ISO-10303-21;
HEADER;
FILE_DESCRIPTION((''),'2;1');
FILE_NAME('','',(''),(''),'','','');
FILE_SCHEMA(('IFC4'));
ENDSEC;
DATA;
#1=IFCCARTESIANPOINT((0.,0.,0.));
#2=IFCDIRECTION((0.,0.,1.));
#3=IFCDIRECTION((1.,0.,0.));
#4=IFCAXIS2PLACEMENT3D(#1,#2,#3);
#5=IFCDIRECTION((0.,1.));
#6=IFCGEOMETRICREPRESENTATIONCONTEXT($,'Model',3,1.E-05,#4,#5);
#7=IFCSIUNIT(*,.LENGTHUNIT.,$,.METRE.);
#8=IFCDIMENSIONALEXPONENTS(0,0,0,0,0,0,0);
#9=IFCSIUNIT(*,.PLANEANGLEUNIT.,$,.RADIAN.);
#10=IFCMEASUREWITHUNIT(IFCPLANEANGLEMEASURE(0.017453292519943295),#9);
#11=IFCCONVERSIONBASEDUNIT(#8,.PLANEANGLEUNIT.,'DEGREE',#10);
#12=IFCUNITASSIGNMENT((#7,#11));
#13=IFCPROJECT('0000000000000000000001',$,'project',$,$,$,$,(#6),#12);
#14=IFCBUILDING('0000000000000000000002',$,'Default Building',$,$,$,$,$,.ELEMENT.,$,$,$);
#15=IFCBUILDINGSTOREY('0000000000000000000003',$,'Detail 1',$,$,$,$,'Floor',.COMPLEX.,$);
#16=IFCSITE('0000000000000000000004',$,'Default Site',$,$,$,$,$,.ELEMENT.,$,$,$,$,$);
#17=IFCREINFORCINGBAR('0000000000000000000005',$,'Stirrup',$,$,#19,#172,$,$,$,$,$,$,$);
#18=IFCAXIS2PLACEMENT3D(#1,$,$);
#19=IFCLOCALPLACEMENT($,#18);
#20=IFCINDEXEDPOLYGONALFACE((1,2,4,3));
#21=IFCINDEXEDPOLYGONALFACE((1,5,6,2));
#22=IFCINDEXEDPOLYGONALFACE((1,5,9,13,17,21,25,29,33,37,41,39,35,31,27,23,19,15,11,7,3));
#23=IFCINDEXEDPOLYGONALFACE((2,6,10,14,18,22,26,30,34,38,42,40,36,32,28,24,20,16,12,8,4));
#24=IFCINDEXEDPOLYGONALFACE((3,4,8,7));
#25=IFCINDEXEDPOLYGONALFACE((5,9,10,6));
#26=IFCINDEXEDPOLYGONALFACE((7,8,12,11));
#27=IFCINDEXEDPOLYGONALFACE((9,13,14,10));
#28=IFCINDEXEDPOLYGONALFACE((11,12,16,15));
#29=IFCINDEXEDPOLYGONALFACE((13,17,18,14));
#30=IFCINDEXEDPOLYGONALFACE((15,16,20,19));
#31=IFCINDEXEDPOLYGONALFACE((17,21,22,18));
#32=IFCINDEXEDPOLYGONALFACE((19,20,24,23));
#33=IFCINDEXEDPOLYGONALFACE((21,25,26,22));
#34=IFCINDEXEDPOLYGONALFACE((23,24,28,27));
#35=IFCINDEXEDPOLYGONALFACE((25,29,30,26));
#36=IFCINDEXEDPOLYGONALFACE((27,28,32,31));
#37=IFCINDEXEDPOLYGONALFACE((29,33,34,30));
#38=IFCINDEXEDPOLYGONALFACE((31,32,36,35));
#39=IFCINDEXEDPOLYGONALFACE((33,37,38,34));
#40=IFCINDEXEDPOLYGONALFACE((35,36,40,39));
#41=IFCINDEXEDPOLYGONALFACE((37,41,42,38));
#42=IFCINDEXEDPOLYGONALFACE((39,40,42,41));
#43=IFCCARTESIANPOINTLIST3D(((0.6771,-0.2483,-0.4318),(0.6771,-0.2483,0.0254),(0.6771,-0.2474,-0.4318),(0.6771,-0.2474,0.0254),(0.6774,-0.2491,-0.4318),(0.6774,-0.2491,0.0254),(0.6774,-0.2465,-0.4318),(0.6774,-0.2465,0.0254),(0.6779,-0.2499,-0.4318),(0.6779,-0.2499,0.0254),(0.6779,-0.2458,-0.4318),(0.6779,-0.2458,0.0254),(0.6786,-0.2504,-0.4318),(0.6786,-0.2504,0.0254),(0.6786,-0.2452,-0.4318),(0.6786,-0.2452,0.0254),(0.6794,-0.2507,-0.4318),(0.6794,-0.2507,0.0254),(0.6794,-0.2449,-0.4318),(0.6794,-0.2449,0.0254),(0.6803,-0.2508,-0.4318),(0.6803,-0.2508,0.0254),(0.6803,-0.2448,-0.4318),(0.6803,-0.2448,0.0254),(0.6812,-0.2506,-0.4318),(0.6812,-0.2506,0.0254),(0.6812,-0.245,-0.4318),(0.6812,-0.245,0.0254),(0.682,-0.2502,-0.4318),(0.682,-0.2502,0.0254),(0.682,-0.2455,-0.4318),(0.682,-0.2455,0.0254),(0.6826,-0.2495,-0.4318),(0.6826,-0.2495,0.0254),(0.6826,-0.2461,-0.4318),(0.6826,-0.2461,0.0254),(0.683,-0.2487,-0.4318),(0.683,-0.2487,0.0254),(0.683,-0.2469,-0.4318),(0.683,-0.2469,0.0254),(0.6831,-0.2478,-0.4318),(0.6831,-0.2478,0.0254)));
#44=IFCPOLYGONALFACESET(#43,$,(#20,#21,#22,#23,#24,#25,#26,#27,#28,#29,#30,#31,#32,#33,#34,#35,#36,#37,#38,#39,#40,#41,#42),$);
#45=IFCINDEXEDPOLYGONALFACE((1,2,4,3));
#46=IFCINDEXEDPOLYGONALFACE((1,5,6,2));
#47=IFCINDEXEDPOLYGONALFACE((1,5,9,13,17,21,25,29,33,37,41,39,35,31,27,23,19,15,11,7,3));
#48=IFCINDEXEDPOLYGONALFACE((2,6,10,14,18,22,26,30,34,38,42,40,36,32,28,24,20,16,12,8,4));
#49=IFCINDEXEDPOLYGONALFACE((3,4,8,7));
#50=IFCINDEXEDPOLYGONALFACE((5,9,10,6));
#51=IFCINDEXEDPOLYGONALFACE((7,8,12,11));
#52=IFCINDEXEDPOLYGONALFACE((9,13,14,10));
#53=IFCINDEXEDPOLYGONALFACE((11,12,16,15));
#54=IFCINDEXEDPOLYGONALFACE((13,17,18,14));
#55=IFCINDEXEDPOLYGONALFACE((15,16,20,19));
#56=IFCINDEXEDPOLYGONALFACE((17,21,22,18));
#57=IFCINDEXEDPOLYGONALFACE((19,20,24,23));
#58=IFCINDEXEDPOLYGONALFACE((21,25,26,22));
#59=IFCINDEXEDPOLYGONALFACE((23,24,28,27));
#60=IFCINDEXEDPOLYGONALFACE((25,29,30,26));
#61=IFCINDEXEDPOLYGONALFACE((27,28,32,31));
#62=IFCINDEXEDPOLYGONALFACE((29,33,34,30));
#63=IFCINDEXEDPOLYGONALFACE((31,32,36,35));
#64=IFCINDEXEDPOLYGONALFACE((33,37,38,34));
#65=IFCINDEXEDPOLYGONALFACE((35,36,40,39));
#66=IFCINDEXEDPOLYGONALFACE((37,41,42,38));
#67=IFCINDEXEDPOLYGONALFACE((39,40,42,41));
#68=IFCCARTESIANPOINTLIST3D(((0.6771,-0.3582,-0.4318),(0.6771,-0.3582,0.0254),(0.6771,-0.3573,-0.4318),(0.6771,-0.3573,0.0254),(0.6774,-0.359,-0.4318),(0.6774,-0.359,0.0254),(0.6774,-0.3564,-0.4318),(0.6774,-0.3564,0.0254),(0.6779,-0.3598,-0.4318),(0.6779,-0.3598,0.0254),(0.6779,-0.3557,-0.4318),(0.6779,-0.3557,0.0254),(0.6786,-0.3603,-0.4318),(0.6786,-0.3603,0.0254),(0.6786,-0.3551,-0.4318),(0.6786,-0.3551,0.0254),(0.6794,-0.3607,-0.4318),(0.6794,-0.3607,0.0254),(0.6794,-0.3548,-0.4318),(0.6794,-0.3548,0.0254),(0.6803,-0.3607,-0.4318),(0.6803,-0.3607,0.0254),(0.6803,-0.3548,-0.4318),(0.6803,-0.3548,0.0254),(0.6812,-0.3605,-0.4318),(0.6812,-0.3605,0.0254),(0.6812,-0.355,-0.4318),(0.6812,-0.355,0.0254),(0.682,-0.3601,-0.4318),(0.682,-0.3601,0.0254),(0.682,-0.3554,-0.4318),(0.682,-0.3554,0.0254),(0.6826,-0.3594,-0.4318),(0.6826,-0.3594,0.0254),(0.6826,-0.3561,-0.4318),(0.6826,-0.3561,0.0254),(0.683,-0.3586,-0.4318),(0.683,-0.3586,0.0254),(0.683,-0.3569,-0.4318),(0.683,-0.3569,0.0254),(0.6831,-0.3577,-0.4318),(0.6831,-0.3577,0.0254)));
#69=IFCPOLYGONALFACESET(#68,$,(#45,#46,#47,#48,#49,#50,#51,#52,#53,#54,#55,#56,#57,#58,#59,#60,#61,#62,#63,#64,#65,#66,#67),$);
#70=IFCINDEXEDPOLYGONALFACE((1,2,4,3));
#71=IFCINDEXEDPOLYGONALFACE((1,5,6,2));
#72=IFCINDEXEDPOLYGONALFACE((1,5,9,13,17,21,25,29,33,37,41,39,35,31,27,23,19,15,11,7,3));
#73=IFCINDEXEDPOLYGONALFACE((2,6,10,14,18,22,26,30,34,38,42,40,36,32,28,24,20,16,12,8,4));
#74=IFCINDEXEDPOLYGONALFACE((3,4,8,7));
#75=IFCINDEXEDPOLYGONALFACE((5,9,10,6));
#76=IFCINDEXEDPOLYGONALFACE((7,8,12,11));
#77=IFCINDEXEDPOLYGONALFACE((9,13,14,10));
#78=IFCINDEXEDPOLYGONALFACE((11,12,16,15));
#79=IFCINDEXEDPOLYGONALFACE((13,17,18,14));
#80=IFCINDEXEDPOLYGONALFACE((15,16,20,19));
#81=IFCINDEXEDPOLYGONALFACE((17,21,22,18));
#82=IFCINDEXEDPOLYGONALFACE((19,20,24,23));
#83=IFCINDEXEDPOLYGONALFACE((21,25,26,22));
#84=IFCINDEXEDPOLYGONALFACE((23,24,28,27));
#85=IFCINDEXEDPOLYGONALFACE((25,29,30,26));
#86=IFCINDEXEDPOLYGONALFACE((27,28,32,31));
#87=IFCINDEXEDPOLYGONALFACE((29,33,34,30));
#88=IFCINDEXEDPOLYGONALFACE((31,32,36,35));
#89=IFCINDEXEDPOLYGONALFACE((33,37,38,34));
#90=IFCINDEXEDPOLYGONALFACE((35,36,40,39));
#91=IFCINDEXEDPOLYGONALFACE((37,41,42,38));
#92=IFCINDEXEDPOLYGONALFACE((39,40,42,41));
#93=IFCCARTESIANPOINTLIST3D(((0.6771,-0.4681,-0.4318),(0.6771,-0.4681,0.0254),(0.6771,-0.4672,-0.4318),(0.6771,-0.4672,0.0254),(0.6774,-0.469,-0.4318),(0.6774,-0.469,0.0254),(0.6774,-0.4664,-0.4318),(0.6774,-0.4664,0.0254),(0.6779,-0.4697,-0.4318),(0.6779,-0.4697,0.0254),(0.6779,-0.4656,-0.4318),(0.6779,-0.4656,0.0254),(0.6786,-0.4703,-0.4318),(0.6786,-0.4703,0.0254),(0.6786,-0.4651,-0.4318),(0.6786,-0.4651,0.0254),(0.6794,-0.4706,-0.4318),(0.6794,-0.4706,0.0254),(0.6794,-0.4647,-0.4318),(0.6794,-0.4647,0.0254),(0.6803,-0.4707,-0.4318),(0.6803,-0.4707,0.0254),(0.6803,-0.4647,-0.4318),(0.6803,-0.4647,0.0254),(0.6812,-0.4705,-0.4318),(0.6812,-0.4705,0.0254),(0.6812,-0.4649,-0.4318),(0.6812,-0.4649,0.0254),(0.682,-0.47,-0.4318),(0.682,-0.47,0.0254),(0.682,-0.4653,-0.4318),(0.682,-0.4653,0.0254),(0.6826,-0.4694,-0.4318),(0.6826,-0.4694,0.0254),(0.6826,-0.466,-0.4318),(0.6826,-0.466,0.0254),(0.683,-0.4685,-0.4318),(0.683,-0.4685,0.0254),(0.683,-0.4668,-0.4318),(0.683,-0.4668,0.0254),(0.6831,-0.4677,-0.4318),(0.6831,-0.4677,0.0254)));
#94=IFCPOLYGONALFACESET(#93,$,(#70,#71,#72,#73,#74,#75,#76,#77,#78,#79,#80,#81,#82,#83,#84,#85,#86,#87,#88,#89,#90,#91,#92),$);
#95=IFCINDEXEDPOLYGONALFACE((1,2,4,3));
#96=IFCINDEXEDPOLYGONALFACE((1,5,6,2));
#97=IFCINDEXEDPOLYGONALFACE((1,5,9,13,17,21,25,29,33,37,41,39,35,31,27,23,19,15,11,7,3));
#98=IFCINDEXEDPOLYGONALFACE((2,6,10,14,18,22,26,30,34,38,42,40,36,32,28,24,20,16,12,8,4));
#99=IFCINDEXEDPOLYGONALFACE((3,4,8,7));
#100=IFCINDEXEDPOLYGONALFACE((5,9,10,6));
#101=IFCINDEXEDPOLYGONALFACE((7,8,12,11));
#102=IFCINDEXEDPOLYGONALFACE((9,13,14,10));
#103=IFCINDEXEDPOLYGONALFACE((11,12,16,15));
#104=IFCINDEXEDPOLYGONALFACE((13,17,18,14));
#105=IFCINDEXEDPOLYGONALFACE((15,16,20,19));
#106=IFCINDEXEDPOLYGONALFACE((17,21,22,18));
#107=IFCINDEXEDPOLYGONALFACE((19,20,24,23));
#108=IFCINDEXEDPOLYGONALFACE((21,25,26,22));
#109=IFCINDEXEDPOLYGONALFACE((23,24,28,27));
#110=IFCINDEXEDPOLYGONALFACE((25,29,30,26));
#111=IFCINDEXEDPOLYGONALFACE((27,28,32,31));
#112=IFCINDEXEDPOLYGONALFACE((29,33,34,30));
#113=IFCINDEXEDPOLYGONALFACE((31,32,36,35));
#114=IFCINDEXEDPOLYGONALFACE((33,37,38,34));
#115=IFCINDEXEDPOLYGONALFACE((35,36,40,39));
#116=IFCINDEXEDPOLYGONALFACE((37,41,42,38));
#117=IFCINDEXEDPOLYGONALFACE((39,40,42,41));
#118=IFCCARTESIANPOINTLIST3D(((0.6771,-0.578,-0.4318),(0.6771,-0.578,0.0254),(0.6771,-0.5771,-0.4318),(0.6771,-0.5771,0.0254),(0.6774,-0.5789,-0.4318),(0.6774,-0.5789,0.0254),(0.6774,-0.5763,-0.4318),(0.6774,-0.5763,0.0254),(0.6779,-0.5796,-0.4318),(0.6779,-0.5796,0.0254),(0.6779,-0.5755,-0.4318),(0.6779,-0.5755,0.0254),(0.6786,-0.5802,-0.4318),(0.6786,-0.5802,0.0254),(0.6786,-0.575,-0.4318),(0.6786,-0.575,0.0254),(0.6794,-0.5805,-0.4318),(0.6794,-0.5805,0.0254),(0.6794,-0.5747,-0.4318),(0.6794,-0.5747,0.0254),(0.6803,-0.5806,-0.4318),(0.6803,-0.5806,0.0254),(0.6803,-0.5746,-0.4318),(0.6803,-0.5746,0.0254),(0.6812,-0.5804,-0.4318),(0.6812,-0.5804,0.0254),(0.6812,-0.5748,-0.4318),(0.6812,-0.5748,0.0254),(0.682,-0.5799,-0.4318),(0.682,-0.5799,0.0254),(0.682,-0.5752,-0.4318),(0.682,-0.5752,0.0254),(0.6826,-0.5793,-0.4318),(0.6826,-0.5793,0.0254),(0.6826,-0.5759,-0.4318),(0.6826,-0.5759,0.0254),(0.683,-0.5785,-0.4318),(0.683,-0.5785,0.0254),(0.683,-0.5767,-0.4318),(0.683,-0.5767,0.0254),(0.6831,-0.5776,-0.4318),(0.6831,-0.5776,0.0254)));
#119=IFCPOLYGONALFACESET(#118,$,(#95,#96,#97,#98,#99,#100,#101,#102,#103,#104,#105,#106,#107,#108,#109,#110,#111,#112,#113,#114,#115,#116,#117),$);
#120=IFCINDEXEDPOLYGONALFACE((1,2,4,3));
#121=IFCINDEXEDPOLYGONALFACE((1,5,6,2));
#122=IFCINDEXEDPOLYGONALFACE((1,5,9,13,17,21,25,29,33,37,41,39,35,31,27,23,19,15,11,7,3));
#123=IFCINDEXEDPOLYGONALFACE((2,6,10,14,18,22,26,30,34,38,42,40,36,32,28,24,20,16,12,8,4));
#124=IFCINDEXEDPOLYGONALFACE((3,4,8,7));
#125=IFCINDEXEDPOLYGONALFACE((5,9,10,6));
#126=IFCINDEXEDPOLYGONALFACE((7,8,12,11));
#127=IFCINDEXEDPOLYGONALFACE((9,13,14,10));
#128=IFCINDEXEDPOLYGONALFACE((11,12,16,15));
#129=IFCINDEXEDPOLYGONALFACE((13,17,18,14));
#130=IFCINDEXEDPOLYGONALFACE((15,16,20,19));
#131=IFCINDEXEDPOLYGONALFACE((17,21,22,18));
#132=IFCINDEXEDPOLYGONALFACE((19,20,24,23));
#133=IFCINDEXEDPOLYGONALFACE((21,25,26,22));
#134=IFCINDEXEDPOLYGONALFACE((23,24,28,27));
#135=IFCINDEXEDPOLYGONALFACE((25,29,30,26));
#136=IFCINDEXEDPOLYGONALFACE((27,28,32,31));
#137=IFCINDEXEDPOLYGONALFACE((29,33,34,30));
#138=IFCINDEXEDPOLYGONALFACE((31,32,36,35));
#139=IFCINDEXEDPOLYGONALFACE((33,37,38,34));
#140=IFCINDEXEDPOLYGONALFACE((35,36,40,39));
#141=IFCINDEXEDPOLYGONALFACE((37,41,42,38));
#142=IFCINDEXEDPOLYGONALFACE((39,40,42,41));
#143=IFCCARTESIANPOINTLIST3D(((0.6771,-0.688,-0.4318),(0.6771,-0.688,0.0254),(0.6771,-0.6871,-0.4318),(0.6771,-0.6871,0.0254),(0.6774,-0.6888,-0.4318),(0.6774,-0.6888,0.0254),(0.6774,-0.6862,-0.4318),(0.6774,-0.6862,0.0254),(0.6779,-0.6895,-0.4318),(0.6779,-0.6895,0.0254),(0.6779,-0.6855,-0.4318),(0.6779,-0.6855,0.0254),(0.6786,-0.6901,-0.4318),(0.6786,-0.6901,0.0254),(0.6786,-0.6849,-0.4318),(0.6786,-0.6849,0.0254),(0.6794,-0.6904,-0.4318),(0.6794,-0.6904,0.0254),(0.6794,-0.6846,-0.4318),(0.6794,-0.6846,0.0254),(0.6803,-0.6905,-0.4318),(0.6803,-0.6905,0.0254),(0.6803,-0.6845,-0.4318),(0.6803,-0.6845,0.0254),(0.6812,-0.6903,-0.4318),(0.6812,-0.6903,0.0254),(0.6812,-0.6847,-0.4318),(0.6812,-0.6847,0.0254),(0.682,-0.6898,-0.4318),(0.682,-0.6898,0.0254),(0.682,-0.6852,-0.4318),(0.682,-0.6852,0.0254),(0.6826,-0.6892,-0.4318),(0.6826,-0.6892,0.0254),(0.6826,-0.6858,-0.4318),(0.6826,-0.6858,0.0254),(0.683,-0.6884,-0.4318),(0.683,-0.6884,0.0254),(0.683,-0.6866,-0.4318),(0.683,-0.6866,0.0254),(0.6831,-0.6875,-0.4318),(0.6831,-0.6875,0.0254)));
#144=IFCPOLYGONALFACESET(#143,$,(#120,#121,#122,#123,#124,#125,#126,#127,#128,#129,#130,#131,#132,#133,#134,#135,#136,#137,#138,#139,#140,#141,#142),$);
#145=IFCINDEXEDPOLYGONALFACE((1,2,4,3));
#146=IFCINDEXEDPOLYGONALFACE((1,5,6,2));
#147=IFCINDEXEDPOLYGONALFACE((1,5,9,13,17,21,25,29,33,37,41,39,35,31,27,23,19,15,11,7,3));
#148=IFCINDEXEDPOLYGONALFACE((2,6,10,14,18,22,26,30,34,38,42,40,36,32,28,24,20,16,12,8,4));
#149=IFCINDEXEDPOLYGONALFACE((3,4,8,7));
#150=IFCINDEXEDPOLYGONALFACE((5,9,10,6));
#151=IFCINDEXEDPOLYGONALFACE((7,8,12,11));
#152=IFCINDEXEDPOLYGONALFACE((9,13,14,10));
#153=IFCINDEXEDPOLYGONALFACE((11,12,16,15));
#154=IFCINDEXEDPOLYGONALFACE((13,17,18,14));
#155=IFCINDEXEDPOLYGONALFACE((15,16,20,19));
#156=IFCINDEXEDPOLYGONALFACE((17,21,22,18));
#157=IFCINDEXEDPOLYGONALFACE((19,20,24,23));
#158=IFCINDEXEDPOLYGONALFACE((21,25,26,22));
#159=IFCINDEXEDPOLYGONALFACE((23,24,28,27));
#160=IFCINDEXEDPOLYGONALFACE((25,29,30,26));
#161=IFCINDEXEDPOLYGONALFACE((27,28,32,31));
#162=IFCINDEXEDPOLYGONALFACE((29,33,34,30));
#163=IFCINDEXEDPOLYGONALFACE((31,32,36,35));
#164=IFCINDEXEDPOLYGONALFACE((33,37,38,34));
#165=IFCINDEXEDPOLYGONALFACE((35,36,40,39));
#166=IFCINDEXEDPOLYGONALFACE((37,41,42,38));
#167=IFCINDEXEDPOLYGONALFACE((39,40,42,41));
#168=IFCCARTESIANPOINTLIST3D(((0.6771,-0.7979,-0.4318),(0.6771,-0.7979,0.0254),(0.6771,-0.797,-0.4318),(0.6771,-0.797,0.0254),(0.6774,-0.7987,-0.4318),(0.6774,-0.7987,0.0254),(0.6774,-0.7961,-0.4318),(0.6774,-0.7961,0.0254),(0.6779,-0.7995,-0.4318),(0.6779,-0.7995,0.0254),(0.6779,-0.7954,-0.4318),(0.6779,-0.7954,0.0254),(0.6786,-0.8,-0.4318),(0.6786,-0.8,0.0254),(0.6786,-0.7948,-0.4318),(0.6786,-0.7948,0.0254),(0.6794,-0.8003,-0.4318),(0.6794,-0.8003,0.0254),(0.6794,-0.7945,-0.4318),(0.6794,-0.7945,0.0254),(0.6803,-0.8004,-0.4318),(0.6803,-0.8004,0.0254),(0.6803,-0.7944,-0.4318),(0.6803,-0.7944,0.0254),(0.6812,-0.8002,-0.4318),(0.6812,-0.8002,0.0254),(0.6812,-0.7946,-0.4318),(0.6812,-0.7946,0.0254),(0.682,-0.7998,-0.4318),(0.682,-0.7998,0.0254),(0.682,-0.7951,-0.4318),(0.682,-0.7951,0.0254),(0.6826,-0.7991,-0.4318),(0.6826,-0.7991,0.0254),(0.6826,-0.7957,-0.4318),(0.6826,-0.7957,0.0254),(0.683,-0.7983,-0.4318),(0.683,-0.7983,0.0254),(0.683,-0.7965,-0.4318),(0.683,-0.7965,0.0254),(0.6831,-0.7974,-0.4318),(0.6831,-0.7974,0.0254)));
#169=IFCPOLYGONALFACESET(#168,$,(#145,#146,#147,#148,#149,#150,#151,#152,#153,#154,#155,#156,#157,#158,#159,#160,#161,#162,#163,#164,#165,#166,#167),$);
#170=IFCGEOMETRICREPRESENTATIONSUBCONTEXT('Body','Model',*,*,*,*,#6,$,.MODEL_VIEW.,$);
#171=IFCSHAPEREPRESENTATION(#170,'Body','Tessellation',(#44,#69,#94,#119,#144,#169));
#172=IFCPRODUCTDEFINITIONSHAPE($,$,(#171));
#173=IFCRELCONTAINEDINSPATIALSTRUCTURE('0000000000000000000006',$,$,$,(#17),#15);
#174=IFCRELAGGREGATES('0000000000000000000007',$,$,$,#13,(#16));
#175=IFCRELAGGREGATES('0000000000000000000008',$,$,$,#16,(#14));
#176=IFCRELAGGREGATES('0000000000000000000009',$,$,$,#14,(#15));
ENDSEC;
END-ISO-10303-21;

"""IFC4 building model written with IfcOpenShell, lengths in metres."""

from ifc_helpers import new_model, entity, si_unit, converted_unit, direction, origin_with_axes, place, context, subcontext, project, spatial, element, save


model = new_model("IFC4")

# Units and contexts
model_context = context("Model", 3, precision=1e-05, world=origin_with_axes(), true_north=direction((0.0, 1.0)))
body_context = subcontext(model_context, "Body", "Model", "MODEL_VIEW")
ifc_project = project(units=[si_unit("LENGTHUNIT", "METRE"), converted_unit("PLANEANGLEUNIT", "DEGREE", entity("IfcPlaneAngleMeasure", 0.017453292519943295), si_unit("PLANEANGLEUNIT", "RADIAN"), dimensions=[0, 0, 0, 0, 0, 0, 0])], contexts=[model_context])

# Site, building, storey
site = spatial("IfcSite", under=ifc_project, Name="Default Site", CompositionType="ELEMENT")
building = spatial("IfcBuilding", under=site, Name="Default Building", CompositionType="ELEMENT")
storey = spatial("IfcBuildingStorey", under=building, Name="Detail 1", LongName="Floor", CompositionType="COMPLEX")

# Shared definitions
placement = place(None, origin_with_axes())

# Reinforcing bar
element("IfcReinforcingBar", 1, at=placement, inside=storey, Name="Stirrup", context=body_context, shape_type="SweptSolid", body=[
    entity("IfcSweptDiskSolid", entity("IfcCompositeCurve", [entity("IfcCompositeCurveSegment", "CONTINUOUS", True, entity("IfcPolyline", [entity("IfcCartesianPoint", [0.6801, -0.2478, -0.4318]), entity("IfcCartesianPoint", [0.6801, -0.2478, 0.0254])]))], False), 0.003),
    entity("IfcSweptDiskSolid", entity("IfcCompositeCurve", [entity("IfcCompositeCurveSegment", "CONTINUOUS", True, entity("IfcPolyline", [entity("IfcCartesianPoint", [0.6801, -0.3577, -0.4318]), entity("IfcCartesianPoint", [0.6801, -0.3577, 0.0254])]))], False), 0.003),
    entity("IfcSweptDiskSolid", entity("IfcCompositeCurve", [entity("IfcCompositeCurveSegment", "CONTINUOUS", True, entity("IfcPolyline", [entity("IfcCartesianPoint", [0.6801, -0.4677, -0.4318]), entity("IfcCartesianPoint", [0.6801, -0.4677, 0.0254])]))], False), 0.003),
    entity("IfcSweptDiskSolid", entity("IfcCompositeCurve", [entity("IfcCompositeCurveSegment", "CONTINUOUS", True, entity("IfcPolyline", [entity("IfcCartesianPoint", [0.6801, -0.5776, -0.4318]), entity("IfcCartesianPoint", [0.6801, -0.5776, 0.0254])]))], False), 0.003),
    entity("IfcSweptDiskSolid", entity("IfcCompositeCurve", [entity("IfcCompositeCurveSegment", "CONTINUOUS", True, entity("IfcPolyline", [entity("IfcCartesianPoint", [0.6801, -0.6875, -0.4318]), entity("IfcCartesianPoint", [0.6801, -0.6875, 0.0254])]))], False), 0.003),
    entity("IfcSweptDiskSolid", entity("IfcCompositeCurve", [entity("IfcCompositeCurveSegment", "CONTINUOUS", True, entity("IfcPolyline", [entity("IfcCartesianPoint", [0.6801, -0.7974, -0.4318]), entity("IfcCartesianPoint", [0.6801, -0.7974, 0.0254])]))], False), 0.003),
])

save(model, "model.ifc")
